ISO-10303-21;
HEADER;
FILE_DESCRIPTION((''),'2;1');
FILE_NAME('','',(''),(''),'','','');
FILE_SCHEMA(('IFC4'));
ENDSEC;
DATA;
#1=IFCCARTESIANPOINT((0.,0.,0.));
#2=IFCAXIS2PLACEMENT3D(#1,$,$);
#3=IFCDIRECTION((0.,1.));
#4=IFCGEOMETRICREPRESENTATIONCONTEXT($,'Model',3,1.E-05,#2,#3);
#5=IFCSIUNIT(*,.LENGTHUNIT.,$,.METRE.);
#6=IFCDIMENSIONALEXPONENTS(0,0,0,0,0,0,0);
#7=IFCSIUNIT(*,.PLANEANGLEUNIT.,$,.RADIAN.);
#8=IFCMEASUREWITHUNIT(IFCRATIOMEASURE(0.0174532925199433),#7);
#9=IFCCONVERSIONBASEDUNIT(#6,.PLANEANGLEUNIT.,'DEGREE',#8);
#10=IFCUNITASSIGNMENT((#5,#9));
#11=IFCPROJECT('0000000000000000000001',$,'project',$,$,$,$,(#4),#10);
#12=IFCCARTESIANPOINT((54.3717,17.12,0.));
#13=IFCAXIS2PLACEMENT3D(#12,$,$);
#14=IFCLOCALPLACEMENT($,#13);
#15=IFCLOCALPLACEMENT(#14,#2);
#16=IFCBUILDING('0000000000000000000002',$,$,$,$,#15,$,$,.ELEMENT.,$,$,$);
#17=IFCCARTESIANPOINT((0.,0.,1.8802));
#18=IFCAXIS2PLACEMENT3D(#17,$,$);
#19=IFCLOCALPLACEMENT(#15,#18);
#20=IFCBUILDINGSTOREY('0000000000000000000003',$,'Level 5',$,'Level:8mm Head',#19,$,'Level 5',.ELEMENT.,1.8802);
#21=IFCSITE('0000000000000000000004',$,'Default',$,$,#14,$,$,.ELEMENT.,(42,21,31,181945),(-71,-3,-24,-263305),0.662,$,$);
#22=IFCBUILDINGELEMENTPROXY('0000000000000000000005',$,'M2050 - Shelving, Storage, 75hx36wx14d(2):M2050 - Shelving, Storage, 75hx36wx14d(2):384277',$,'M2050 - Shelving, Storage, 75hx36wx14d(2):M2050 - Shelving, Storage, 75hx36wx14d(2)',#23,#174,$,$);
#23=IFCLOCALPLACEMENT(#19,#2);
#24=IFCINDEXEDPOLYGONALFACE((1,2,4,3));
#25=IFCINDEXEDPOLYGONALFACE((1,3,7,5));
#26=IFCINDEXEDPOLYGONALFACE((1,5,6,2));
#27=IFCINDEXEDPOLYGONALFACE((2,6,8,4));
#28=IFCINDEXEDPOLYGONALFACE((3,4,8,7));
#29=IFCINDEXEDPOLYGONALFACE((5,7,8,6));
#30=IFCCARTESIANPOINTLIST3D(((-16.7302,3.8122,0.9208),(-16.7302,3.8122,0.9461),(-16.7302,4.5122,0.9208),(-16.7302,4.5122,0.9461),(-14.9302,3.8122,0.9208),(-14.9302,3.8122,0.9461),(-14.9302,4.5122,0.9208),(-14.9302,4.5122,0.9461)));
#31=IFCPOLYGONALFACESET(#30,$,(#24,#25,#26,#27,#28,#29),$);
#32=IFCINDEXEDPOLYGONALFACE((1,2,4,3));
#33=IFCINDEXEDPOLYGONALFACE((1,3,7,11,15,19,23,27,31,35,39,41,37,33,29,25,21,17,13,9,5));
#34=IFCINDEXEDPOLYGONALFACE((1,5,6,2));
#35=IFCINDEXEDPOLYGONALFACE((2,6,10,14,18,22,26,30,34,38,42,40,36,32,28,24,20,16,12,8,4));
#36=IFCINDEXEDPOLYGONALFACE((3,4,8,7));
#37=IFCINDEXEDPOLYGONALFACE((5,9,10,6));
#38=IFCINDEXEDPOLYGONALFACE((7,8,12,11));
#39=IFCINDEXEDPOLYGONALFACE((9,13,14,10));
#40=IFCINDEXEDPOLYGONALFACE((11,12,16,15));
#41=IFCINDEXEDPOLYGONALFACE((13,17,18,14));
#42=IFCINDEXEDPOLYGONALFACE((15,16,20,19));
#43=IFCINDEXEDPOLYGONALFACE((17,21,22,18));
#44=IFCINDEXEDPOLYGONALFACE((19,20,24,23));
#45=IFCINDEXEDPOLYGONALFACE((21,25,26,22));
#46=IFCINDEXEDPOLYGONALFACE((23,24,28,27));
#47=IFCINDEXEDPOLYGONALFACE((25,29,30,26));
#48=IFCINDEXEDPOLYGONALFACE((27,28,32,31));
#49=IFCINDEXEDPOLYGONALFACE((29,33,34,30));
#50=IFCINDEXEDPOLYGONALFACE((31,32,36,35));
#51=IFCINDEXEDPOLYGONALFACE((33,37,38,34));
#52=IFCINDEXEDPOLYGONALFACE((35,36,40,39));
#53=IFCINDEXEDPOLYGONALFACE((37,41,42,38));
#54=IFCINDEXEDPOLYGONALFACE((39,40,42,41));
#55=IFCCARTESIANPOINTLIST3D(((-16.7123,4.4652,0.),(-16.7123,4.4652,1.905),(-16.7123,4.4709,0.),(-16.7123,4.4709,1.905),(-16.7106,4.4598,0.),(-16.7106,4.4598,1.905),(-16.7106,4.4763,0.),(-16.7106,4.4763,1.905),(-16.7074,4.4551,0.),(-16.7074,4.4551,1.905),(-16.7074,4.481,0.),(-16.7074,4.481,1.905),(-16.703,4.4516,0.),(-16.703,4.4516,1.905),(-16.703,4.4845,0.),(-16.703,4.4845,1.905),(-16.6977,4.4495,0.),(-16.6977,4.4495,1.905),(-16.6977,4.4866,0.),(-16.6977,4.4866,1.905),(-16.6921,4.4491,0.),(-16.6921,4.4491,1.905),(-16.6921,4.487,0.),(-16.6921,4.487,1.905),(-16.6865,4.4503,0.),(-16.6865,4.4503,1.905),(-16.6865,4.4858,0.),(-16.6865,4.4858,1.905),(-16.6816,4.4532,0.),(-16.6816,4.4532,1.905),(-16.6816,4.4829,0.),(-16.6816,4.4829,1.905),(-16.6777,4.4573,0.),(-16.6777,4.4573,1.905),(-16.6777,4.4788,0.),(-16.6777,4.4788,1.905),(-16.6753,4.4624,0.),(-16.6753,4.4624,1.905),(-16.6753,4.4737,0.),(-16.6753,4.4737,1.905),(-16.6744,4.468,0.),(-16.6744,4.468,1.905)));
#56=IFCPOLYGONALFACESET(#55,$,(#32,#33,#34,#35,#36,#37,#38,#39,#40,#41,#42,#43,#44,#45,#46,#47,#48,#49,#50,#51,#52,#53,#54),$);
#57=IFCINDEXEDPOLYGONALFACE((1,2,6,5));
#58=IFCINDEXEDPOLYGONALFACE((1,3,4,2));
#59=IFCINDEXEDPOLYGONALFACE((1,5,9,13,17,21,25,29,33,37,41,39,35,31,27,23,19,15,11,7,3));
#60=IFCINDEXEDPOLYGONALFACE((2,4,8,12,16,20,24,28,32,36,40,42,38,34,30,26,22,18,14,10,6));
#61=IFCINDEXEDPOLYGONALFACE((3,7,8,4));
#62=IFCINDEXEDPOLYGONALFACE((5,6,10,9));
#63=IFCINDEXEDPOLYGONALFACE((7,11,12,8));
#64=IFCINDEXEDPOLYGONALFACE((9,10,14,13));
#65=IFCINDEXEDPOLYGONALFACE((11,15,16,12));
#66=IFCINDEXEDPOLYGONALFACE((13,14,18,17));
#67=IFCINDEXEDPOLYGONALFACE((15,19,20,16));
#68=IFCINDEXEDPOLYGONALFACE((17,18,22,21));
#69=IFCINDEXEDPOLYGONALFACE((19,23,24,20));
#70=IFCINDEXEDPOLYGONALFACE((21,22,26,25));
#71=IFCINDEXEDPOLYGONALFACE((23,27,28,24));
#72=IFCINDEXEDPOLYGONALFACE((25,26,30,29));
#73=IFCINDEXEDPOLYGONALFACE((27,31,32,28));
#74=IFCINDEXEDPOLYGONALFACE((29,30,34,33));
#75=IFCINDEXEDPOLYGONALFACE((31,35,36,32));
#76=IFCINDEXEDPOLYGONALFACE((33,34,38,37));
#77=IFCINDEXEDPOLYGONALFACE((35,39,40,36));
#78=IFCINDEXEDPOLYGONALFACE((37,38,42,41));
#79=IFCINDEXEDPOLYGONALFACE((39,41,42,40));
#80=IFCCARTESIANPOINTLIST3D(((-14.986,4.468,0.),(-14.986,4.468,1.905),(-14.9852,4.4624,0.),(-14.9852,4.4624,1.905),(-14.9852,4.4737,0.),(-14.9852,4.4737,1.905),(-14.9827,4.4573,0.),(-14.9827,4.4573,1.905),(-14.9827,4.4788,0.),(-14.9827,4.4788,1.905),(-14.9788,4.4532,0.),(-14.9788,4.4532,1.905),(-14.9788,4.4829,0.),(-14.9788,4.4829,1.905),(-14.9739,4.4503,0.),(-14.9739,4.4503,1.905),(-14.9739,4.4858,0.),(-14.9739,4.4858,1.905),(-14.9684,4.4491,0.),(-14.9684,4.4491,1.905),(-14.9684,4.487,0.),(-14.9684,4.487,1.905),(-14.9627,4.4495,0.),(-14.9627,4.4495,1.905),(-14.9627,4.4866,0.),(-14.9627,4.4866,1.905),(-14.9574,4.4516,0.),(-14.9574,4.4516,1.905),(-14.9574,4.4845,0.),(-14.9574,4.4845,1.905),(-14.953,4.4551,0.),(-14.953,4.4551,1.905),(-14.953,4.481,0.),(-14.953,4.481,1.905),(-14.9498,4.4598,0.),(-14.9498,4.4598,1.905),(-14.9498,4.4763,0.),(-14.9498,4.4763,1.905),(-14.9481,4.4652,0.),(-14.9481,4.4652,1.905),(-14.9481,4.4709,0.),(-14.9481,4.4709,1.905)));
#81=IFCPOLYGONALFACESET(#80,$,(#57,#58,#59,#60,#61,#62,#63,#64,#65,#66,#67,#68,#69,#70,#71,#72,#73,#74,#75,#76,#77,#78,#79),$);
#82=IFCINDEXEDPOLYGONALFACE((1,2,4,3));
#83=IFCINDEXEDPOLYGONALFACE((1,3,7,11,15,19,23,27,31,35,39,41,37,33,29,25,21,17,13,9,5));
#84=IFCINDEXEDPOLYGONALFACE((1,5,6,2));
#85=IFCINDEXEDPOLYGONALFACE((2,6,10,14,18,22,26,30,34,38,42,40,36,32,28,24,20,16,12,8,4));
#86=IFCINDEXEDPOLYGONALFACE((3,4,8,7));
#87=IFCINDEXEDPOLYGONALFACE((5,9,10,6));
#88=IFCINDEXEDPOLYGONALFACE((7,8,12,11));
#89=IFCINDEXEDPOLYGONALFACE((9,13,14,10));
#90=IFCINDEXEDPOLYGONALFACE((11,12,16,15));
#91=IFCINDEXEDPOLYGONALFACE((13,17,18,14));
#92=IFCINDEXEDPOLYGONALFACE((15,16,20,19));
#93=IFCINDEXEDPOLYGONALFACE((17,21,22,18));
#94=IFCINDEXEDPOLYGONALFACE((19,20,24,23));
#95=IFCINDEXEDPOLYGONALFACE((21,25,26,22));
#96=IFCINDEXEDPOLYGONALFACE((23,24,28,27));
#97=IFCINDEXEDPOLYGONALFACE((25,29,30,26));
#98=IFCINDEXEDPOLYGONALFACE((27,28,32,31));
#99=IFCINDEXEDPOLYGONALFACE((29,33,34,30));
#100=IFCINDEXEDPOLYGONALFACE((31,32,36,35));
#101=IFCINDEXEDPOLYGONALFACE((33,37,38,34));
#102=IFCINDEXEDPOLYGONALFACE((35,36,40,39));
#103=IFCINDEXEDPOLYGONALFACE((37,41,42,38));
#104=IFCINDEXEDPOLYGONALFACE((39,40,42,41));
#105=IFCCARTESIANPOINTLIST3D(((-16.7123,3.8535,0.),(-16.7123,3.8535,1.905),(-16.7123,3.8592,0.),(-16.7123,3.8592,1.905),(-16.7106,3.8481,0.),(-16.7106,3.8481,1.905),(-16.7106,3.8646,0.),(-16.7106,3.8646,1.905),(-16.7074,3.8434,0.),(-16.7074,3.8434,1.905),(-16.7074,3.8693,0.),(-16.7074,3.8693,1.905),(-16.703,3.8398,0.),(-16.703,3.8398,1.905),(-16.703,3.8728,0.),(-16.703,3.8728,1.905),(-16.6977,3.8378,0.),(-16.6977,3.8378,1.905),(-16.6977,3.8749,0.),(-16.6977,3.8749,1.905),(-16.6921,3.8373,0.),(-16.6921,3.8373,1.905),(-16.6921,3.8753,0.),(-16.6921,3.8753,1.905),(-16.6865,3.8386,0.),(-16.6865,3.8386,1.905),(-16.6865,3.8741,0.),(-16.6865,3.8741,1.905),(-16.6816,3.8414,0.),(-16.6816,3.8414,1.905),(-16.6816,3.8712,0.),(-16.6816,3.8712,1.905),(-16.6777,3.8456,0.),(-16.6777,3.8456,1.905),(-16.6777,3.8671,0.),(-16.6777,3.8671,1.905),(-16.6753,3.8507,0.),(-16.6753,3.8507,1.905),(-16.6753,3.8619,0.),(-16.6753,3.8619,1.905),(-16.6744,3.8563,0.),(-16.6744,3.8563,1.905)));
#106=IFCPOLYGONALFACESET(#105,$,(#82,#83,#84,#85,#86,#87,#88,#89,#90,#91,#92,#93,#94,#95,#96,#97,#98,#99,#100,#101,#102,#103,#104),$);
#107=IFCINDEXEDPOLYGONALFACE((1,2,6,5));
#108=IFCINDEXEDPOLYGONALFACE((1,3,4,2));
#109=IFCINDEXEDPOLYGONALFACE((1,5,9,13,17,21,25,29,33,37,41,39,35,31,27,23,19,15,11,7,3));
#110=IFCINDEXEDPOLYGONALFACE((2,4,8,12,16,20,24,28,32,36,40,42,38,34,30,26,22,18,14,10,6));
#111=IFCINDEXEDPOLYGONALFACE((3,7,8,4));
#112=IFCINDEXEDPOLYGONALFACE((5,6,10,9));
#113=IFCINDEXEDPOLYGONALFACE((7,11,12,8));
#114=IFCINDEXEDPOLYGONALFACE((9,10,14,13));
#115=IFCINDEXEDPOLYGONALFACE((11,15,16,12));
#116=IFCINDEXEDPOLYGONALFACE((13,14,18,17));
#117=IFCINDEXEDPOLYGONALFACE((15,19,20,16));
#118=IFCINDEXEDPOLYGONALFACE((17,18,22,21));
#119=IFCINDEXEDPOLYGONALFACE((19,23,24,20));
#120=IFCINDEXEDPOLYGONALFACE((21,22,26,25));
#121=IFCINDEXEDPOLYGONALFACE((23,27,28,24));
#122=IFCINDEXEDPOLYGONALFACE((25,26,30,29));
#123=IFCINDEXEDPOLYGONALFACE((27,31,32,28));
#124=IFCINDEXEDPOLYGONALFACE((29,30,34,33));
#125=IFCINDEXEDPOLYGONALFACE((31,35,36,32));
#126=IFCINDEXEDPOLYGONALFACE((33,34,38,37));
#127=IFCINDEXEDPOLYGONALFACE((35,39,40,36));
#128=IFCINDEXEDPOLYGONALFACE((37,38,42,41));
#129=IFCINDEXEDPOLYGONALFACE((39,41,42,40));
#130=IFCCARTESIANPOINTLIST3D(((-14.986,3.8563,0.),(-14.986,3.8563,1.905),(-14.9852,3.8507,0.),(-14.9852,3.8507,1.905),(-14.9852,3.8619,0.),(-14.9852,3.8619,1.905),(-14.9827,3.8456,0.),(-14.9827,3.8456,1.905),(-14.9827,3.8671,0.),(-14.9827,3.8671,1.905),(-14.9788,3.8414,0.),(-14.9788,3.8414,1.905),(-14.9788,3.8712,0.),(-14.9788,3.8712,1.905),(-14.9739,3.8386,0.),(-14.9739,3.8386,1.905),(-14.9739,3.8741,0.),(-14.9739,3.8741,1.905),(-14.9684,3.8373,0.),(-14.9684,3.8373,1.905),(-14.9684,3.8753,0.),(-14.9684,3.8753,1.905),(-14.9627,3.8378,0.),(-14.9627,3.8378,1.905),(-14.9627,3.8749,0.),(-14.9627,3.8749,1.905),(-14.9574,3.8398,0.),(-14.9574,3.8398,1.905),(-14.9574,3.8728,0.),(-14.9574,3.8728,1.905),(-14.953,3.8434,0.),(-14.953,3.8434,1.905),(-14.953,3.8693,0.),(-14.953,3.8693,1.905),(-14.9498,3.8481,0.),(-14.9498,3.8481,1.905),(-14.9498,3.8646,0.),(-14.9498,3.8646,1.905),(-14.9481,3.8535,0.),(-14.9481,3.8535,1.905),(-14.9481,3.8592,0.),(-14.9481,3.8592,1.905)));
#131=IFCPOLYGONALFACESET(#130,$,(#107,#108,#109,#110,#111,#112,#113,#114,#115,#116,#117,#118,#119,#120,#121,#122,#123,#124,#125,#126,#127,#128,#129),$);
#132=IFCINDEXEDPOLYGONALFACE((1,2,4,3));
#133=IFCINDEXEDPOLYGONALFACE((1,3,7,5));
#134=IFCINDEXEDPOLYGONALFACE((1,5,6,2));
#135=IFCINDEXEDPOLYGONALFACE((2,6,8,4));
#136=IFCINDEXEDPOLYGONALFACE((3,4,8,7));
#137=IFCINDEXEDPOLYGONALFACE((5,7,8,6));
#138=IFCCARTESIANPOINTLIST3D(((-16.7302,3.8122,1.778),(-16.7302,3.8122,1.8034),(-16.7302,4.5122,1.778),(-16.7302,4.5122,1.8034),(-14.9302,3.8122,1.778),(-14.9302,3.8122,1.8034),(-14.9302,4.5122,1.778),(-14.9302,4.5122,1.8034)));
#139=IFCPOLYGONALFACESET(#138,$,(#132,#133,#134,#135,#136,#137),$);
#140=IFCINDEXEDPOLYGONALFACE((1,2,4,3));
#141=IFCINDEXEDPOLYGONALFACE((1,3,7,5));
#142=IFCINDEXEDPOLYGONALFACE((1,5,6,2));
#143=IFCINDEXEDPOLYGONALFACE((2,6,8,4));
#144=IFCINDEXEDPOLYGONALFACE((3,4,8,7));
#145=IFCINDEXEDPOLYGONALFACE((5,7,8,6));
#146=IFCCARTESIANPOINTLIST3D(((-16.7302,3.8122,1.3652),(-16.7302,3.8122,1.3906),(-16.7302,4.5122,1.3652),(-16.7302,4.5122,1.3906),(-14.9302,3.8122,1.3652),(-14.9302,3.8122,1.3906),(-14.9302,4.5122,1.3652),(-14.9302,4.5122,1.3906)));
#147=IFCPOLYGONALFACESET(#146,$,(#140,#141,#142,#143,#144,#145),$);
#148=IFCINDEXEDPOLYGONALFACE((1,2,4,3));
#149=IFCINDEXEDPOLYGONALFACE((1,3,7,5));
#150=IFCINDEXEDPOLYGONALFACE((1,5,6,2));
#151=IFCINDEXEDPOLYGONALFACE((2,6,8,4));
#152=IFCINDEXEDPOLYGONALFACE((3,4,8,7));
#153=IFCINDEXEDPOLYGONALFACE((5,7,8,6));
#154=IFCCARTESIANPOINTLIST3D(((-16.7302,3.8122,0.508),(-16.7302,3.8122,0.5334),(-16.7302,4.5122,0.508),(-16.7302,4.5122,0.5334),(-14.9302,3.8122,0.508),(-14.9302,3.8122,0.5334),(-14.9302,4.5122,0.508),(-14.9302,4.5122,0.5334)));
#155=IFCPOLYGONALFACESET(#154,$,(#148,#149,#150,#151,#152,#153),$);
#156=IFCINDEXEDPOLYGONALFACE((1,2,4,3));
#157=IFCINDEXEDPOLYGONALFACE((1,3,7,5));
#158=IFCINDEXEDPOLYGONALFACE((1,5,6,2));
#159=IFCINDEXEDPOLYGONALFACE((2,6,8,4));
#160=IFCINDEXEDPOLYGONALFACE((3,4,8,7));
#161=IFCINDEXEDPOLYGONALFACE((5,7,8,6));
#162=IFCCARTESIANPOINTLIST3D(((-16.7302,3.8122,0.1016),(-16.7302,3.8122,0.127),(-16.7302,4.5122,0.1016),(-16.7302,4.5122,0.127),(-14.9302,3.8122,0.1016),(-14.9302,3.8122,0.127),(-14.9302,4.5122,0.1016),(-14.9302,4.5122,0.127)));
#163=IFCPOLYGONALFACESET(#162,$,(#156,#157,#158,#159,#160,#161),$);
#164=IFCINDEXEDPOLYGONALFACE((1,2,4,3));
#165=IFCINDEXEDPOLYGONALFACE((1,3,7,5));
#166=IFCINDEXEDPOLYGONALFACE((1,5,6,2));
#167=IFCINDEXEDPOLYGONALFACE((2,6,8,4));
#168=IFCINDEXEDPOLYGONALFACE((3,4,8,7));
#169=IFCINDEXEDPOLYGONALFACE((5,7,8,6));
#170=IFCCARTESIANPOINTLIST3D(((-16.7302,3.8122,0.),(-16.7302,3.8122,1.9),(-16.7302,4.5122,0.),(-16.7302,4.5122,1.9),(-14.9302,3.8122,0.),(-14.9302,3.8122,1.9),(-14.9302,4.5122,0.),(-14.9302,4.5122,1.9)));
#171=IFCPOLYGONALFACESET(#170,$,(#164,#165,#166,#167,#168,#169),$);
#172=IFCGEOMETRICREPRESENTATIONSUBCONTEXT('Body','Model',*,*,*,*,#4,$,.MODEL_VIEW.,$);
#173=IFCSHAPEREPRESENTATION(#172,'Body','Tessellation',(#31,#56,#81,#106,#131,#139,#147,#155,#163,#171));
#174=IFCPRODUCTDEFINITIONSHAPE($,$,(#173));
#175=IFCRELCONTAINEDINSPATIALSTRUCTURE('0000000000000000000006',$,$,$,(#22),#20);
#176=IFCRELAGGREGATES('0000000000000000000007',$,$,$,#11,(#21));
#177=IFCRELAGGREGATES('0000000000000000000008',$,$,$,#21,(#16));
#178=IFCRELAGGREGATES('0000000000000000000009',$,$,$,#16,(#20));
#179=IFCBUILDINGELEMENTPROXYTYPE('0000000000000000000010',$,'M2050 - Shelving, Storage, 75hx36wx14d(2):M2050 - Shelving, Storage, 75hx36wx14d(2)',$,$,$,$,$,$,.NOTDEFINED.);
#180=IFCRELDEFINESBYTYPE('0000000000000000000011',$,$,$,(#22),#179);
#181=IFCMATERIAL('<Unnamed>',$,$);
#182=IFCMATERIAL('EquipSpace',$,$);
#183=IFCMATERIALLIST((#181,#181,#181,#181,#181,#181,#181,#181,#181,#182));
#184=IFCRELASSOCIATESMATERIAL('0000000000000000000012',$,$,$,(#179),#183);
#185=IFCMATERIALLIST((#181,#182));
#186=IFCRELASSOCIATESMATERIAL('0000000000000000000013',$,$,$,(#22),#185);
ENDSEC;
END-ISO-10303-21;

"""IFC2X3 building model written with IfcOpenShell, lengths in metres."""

from ifc_helpers import new_model, entity, si_unit, converted_unit, direction, frame, frame_2d, origin, origin_2d_with_axis, place, context, subcontext, project, spatial, rectangle, circle, extrude, source, transform, mapped, material, material_list, type_object, type_shapes, element, save


model = new_model("IFC2X3")

# Units and contexts
model_context = context("Model", 3, precision=1e-05, world=origin(), true_north=direction((0.0, 1.0)))
body_context = subcontext(model_context, "Body", "Model", "MODEL_VIEW")
ifc_project = project(units=[si_unit("LENGTHUNIT", "METRE"), converted_unit("PLANEANGLEUNIT", "DEGREE", entity("IfcRatioMeasure", 0.0174532925199433), si_unit("PLANEANGLEUNIT", "RADIAN"), dimensions=[0, 0, 0, 0, 0, 0, 0])], contexts=[model_context])

# Site, building, storey
site_placement = place(None, frame((54.3717, 17.12, 0.0)))
site = spatial("IfcSite", under=ifc_project, at=site_placement, Name="Default", CompositionType="ELEMENT", RefLatitude=(42, 21, 31, 181945), RefLongitude=(-71, -3, -24, -263305), RefElevation=0.662)
building_placement = place(site_placement, origin())
building = spatial("IfcBuilding", under=site, at=building_placement, CompositionType="ELEMENT")
storey_placement = place(building_placement, frame((0.0, 0.0, 1.8802)))
storey = spatial("IfcBuildingStorey", under=building, at=storey_placement, Name="Level 5", ObjectType="Level:8mm Head", LongName="Level 5", CompositionType="ELEMENT", Elevation=1.8802)

# Building element proxy
ifc_material_1 = material(Name="<Unnamed>")
ifc_material_2 = material(Name="EquipSpace")
ifc_material_list_1 = material_list([ifc_material_1, ifc_material_1, ifc_material_1, ifc_material_1, ifc_material_1, ifc_material_1, ifc_material_1, ifc_material_1, ifc_material_1, ifc_material_2])
building_element_proxy_type = type_object("IfcBuildingElementProxyType", Name="M2050 - Shelving, Storage, 75hx36wx14d(2):M2050 - Shelving, Storage, 75hx36wx14d(2)", PredefinedType="NOTDEFINED", material=ifc_material_list_1)
shared_shape = source(origin(), body_context, "Body", "SweptSolid", [
    extrude(rectangle(XDim=1.8, YDim=0.7, at=origin_2d_with_axis()), frame((0.0, 0.0, 0.9207), z_axis=(0.0, 0.0, 1.0), x_axis=(-1.0, 0.0, 0.0)), (0.0, 0.0, 1.0), 0.0254),
    extrude(circle(Radius=0.0191, at=origin_2d_with_axis()), frame((0.8633, -0.3059, 0.0), z_axis=(0.0, 0.0, 1.0), x_axis=(-1.0, 0.0, 0.0)), (0.0, 0.0, 1.0), 1.905),
    extrude(circle(Radius=0.0191, at=origin_2d_with_axis()), frame((-0.8633, -0.3059, 0.0)), (0.0, 0.0, 1.0), 1.905),
    extrude(circle(Radius=0.0191, at=origin_2d_with_axis()), frame((0.8633, 0.3059, 0.0), z_axis=(0.0, 0.0, 1.0), x_axis=(-1.0, 0.0, 0.0)), (0.0, 0.0, 1.0), 1.905),
    extrude(circle(Radius=0.0191, at=origin_2d_with_axis()), frame((-0.8633, 0.3059, 0.0)), (0.0, 0.0, 1.0), 1.905),
    extrude(rectangle(XDim=1.8, YDim=0.7, at=origin_2d_with_axis()), frame((0.0, 0.0, 1.778), z_axis=(0.0, 0.0, 1.0), x_axis=(-1.0, 0.0, 0.0)), (0.0, 0.0, 1.0), 0.0254),
    extrude(rectangle(XDim=1.8, YDim=0.7, at=origin_2d_with_axis()), frame((0.0, 0.0, 1.3653), z_axis=(0.0, 0.0, 1.0), x_axis=(-1.0, 0.0, 0.0)), (0.0, 0.0, 1.0), 0.0254),
    extrude(rectangle(XDim=1.8, YDim=0.7, at=origin_2d_with_axis()), frame((0.0, 0.0, 0.508), z_axis=(0.0, 0.0, 1.0), x_axis=(-1.0, 0.0, 0.0)), (0.0, 0.0, 1.0), 0.0254),
    extrude(rectangle(XDim=1.8, YDim=0.7, at=origin_2d_with_axis()), frame((0.0, 0.0, 0.1016), z_axis=(0.0, 0.0, 1.0), x_axis=(-1.0, 0.0, 0.0)), (0.0, 0.0, 1.0), 0.0254),
    extrude(rectangle(XDim=0.7, YDim=1.8, at=frame_2d((0.0, 0.18), x_axis=(1.0, 0.0))), frame((-0.18, 0.0, 0.0), z_axis=(0.0, 0.0, 1.0), x_axis=(0.0, -1.0, 0.0)), (0.0, 0.0, 1.0), 1.9),
])
type_shapes(building_element_proxy_type, [shared_shape])
ifc_material_list_2 = material_list([ifc_material_1, ifc_material_2])
proxy_1_placement = place(storey_placement, frame((-15.8302, 4.1622, 0.0), z_axis=(0.0, 0.0, 1.0), x_axis=(-1.0, 0.0, 0.0)))
element("IfcBuildingElementProxy", 1, at=proxy_1_placement, inside=storey, type_object=building_element_proxy_type, material=ifc_material_list_2, Name="M2050 - Shelving, Storage, 75hx36wx14d(2):M2050 - Shelving, Storage, 75hx36wx14d(2):384277", ObjectType="M2050 - Shelving, Storage, 75hx36wx14d(2):M2050 - Shelving, Storage, 75hx36wx14d(2)", context=body_context, shape_type="MappedRepresentation", body=[
    mapped(shared_shape, transform((0.0, 0.0, 0.0), scale=1.0)),
])

save(model, "model.ifc")
